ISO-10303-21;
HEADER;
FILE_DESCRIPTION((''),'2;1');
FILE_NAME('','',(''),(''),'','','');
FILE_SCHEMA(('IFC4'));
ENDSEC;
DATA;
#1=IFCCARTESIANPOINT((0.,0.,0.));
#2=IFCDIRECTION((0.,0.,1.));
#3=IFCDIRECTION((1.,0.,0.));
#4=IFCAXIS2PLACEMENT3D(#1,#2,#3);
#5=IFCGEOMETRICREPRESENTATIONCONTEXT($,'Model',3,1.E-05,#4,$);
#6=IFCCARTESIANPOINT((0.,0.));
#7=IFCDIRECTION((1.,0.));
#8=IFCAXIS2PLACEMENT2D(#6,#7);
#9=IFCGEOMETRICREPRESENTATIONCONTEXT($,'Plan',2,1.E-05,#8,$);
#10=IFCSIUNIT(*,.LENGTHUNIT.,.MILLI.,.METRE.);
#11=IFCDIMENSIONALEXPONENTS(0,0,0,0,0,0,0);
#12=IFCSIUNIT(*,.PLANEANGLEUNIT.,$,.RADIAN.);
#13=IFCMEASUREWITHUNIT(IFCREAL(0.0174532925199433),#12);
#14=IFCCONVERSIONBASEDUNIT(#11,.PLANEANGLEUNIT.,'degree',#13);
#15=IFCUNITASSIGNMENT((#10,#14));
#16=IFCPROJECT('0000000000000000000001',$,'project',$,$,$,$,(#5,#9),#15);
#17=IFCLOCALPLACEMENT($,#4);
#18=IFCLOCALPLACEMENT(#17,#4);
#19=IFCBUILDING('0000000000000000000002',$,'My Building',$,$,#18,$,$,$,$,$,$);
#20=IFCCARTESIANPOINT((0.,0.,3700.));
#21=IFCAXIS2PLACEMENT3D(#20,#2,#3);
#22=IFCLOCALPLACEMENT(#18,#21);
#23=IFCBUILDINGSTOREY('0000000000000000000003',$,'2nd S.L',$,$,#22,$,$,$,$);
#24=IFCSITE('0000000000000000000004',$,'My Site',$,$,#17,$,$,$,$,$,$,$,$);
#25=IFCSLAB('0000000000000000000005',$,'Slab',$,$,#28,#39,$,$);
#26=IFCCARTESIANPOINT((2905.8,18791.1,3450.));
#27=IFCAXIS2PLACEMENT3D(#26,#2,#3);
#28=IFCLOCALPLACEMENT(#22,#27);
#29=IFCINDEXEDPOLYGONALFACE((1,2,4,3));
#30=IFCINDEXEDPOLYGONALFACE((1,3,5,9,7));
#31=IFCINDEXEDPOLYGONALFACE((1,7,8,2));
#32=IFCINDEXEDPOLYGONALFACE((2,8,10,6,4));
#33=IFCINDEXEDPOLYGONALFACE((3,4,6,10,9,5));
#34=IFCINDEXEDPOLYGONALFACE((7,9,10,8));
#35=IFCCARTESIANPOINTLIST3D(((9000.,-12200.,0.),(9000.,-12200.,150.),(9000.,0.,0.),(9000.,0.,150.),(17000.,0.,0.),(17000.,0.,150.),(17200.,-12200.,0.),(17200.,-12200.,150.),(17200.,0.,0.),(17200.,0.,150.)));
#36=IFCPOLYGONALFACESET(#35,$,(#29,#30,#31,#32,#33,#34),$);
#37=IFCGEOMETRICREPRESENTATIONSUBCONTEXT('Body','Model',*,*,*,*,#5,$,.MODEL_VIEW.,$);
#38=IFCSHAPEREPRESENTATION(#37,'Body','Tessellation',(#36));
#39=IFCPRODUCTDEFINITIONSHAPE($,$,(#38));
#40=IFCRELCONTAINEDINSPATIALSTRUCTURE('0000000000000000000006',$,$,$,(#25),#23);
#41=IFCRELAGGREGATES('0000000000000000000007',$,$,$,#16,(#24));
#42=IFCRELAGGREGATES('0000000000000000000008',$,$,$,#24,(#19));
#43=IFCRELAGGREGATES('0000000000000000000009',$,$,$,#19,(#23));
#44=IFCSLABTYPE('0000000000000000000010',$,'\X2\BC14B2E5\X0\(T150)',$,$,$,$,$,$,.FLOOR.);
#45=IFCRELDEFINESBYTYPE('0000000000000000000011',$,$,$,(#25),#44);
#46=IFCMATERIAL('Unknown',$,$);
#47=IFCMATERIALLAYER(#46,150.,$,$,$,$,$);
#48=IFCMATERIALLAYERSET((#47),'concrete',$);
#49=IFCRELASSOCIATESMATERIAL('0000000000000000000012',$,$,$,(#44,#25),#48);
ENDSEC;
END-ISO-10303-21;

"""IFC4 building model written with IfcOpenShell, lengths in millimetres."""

from ifc_helpers import new_model, entity, si_unit, converted_unit, frame, origin_with_axes, origin_2d_with_axis, place, context, subcontext, project, spatial, indexed_curve, outline, extrude, material, layer, layer_set, layer_usage, type_object, element, save


model = new_model("IFC4")

# Units and contexts
model_context = context("Model", 3, precision=1e-05, world=origin_with_axes())
plan_context = context("Plan", 2, precision=1e-05, world=origin_2d_with_axis())
body_context = subcontext(model_context, "Body", "Model", "MODEL_VIEW")
ifc_project = project(units=[si_unit("LENGTHUNIT", "METRE", prefix="MILLI"), converted_unit("PLANEANGLEUNIT", "degree", entity("IfcReal", 0.0174532925199433), si_unit("PLANEANGLEUNIT", "RADIAN"), dimensions=[0, 0, 0, 0, 0, 0, 0])], contexts=[model_context, plan_context])

# Site, building, storey
site_placement = place(None, origin_with_axes())
site = spatial("IfcSite", under=ifc_project, at=site_placement, Name="My Site")
building_placement = place(site_placement, origin_with_axes())
building = spatial("IfcBuilding", under=site, at=building_placement, Name="My Building")
storey_placement = place(building_placement, frame((0.0, 0.0, 3700.0), z_axis=(0.0, 0.0, 1.0), x_axis=(1.0, 0.0, 0.0)))
storey = spatial("IfcBuildingStorey", under=building, at=storey_placement, Name="2nd S.L")

# Shared definitions
ifc_material_1 = material(Name="Unknown")

# Slab
ifc_layer_1 = layer(ifc_material_1, 150.0)
ifc_layer_set_1 = layer_set([ifc_layer_1], Name="concrete")
slab_type = type_object("IfcSlabType", Name="바닥(T150)", PredefinedType="FLOOR", material=ifc_layer_set_1)
ifc_layer_usage_1 = layer_usage(ifc_layer_set_1, "AXIS3", "POSITIVE", 0.0)
slab_1_placement = place(storey_placement, frame((2905.8, 18791.1, 3450.0), z_axis=(0.0, 0.0, 1.0), x_axis=(1.0, 0.0, 0.0)))
element("IfcSlab", 1, at=slab_1_placement, inside=storey, type_object=slab_type, material=ifc_layer_usage_1, Name="Slab", context=body_context, shape_type="SolidModel", body=[
    extrude(outline(indexed_curve([(9000.0, -12200.0), (17200.0, -12200.0), (17200.0, 0.0), (17000.0, 0.0), (9000.0, 0.0), (9000.0, -12200.0)])), origin_with_axes(), (0.0, 0.0, 1.0), 150.0),
])

save(model, "model.ifc")
